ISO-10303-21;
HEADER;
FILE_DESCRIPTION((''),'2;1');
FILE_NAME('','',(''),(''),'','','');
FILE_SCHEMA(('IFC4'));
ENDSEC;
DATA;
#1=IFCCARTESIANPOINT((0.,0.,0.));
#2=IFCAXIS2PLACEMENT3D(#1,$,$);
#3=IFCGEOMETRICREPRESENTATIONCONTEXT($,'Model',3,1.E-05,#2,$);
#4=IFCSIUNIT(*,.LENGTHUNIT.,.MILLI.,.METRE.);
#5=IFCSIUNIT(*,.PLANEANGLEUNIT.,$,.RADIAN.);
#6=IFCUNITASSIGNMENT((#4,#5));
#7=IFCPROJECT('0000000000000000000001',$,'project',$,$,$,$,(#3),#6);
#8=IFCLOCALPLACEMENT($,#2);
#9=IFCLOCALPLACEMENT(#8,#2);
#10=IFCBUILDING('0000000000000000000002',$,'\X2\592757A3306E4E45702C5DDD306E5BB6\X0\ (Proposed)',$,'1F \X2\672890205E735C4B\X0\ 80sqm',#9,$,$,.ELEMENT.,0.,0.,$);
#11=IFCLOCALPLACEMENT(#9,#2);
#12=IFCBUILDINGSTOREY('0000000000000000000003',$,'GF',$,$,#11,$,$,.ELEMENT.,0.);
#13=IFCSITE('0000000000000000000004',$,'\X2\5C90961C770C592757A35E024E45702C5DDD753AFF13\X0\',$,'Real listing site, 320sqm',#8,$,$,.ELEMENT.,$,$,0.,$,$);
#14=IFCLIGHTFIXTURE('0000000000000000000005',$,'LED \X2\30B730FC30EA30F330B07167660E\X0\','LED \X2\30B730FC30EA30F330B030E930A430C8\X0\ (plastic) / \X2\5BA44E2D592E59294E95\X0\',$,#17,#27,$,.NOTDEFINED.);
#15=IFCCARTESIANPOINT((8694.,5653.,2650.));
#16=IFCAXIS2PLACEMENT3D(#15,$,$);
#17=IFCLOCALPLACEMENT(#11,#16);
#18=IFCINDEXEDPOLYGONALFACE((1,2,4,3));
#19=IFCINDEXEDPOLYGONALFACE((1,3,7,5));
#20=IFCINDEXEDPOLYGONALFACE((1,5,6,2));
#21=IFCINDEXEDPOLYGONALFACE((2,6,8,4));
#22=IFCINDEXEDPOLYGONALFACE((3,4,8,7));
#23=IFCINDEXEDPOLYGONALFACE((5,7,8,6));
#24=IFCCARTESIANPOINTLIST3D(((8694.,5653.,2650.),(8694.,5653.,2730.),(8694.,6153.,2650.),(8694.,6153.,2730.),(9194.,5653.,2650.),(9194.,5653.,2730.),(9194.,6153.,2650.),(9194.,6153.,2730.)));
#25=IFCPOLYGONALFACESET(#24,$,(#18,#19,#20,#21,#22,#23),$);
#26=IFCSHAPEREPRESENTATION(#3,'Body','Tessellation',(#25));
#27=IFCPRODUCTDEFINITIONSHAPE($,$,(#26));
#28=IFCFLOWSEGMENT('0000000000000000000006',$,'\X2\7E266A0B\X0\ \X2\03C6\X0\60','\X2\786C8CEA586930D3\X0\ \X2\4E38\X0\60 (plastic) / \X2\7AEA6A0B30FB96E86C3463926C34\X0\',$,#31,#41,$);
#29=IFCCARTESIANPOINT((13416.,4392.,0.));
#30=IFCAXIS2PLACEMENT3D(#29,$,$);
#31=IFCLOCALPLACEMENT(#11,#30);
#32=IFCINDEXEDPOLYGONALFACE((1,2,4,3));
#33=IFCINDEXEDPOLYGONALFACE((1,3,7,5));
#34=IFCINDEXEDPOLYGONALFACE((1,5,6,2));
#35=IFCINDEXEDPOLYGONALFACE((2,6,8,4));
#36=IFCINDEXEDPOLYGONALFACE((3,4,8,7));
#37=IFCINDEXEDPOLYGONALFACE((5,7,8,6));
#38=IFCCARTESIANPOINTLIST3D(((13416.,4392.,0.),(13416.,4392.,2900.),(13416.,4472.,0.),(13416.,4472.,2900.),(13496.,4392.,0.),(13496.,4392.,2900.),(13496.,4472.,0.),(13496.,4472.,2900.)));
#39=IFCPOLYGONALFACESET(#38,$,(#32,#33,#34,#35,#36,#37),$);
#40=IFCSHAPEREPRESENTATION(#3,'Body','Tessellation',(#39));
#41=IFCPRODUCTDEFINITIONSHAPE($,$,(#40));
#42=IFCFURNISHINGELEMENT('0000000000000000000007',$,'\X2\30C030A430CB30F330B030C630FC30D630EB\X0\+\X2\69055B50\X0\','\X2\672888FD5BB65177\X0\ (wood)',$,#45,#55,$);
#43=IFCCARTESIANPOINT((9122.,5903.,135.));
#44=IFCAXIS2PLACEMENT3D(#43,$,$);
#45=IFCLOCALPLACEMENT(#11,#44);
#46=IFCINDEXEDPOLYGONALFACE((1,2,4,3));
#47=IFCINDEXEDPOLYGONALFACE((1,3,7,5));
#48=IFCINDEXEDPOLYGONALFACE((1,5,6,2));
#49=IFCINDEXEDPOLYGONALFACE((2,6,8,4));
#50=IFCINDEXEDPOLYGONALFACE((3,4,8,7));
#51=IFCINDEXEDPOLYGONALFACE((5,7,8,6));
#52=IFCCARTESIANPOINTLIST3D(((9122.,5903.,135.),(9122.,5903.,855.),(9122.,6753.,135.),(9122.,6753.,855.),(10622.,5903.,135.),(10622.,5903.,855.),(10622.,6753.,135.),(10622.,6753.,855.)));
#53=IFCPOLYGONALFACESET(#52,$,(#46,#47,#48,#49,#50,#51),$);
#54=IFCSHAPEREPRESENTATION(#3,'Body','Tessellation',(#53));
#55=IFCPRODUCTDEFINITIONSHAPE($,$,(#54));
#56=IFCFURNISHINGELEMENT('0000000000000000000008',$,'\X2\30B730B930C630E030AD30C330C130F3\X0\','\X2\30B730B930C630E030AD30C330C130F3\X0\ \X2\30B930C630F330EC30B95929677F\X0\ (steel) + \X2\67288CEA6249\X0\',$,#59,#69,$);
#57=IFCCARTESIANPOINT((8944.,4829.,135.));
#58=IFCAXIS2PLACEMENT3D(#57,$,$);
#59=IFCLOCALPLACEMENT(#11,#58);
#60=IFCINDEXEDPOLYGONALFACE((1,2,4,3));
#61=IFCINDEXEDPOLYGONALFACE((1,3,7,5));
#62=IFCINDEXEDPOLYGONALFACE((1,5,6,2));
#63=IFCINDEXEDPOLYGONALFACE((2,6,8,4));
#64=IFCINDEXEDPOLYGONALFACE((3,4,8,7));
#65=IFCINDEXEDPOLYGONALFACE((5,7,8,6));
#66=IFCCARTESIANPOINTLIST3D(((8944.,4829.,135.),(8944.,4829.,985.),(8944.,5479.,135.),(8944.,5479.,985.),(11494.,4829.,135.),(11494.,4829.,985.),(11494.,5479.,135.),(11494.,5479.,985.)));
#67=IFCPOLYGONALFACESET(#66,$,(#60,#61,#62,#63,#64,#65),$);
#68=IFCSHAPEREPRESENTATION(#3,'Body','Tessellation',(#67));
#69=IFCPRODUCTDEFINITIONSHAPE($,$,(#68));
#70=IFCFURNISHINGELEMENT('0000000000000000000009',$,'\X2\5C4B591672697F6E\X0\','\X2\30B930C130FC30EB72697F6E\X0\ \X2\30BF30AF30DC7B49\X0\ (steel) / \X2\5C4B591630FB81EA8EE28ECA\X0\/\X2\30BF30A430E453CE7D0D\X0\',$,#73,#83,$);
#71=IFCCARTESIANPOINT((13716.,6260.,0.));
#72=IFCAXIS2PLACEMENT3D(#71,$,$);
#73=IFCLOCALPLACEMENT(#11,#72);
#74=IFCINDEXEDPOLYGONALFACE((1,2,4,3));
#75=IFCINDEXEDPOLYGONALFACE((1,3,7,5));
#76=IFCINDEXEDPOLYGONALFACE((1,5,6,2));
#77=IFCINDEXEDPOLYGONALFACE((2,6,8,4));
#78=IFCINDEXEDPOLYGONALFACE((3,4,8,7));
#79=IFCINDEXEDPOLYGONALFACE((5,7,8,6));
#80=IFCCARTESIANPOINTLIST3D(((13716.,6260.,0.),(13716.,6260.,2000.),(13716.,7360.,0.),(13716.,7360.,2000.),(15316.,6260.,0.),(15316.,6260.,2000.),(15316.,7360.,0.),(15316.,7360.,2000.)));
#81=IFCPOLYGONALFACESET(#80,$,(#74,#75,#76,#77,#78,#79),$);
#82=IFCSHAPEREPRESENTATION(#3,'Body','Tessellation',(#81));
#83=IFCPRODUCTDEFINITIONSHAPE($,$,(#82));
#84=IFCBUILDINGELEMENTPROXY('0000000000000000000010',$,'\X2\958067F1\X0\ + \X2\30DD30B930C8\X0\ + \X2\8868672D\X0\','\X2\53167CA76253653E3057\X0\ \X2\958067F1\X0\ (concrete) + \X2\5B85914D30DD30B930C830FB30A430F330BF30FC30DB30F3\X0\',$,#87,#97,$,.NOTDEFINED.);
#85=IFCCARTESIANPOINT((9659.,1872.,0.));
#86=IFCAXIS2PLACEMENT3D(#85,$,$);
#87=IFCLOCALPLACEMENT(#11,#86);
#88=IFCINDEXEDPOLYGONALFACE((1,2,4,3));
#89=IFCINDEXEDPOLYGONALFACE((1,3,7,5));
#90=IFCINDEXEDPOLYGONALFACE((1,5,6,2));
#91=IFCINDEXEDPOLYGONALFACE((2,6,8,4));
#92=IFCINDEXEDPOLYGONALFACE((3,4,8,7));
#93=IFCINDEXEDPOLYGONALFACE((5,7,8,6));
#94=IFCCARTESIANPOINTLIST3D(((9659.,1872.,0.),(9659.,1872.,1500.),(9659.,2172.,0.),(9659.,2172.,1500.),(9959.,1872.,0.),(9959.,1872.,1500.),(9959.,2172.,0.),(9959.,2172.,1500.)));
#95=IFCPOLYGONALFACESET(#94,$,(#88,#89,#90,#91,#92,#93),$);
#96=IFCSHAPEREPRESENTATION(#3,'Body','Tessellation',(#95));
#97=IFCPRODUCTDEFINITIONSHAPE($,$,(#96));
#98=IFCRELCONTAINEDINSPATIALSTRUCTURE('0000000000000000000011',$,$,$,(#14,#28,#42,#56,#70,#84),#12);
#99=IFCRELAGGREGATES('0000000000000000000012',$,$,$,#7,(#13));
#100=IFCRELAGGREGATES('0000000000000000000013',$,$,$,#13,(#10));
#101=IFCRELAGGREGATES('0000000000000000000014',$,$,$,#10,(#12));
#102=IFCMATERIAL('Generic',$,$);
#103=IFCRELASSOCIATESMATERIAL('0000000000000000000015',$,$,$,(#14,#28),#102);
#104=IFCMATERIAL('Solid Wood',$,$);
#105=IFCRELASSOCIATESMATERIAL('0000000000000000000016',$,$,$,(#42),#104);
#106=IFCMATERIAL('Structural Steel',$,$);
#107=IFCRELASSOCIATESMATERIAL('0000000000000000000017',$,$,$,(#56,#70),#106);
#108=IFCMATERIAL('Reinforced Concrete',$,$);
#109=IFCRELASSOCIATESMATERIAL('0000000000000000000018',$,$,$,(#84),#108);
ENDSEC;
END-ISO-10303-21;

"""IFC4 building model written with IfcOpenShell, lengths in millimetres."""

from ifc_helpers import new_model, si_unit, frame, frame_2d, origin, place, context, project, spatial, rectangle, extrude, material, element, save


model = new_model("IFC4")

# Units and contexts
model_context = context("Model", 3, precision=1e-05, world=origin())
ifc_project = project(units=[si_unit("LENGTHUNIT", "METRE", prefix="MILLI"), si_unit("PLANEANGLEUNIT", "RADIAN")], contexts=[model_context])

# Site, building, storey
site_placement = place(None, origin())
site = spatial("IfcSite", under=ifc_project, at=site_placement, Name="岐阜県大垣市久瀬川町３", ObjectType="Real listing site, 320sqm", CompositionType="ELEMENT", RefElevation=0.0)
building_placement = place(site_placement, origin())
building = spatial("IfcBuilding", under=site, at=building_placement, Name="大垣の久瀬川の家 (Proposed)", ObjectType="1F 木造平屋 80sqm", CompositionType="ELEMENT", ElevationOfRefHeight=0.0, ElevationOfTerrain=0.0)
storey_placement = place(building_placement, origin())
storey = spatial("IfcBuildingStorey", under=building, at=storey_placement, Name="GF", CompositionType="ELEMENT", Elevation=0.0)

# Shared definitions
ifc_material_1 = material(Name="Solid Wood")

# Shared definitions
ifc_material_2 = material(Name="Structural Steel")

# Shared definitions
ifc_material_3 = material(Name="Reinforced Concrete")

# Shared definitions
ifc_material_4 = material(Name="Generic")

# Light fixture
light_fixture_placement = place(storey_placement, frame((8694.0, 5653.0, 2650.0)))
element("IfcLightFixture", 1, at=light_fixture_placement, inside=storey, material=ifc_material_4, Name="LED シーリング照明", Description="LED シーリングライト (plastic) / 室中央天井", PredefinedType="NOTDEFINED", context=model_context, shape_type="SweptSolid", body=[
    extrude(rectangle(XDim=500.0, YDim=500.0, at=frame_2d((250.0, 250.0))), frame((8694.0, 5653.0, 2650.0)), (0.0, 0.0, 1.0), 80.0),
])

# Flow segment
flow_segment_placement = place(storey_placement, frame((13416.0, 4392.0, 0.0)))
element("IfcFlowSegment", 2, at=flow_segment_placement, inside=storey, material=ifc_material_4, Name="縦樋 φ60", Description="硬質塩ビ 丸60 (plastic) / 竪樋・雨水排水", context=model_context, shape_type="SweptSolid", body=[
    extrude(rectangle(XDim=80.0, YDim=80.0, at=frame_2d((40.0, 40.0))), frame((13416.0, 4392.0, 0.0)), (0.0, 0.0, 1.0), 2900.0),
])

# Furnishing elements
furnishing_1_placement = place(storey_placement, frame((9122.0, 5903.0, 135.0)))
element("IfcFurnishingElement", 3, at=furnishing_1_placement, inside=storey, material=ifc_material_1, Name="ダイニングテーブル+椅子", Description="木製家具 (wood)", context=model_context, shape_type="SweptSolid", body=[
    extrude(rectangle(XDim=1500.0, YDim=850.0, at=frame_2d((750.0, 425.0))), frame((9122.0, 5903.0, 135.0)), (0.0, 0.0, 1.0), 720.0),
])
furnishing_2_placement = place(storey_placement, frame((8944.0, 4829.0, 135.0)))
element("IfcFurnishingElement", 4, at=furnishing_2_placement, inside=storey, material=ifc_material_2, Name="システムキッチン", Description="システムキッチン ステンレス天板 (steel) + 木質扉", context=model_context, shape_type="SweptSolid", body=[
    extrude(rectangle(XDim=2550.0, YDim=650.0, at=frame_2d((1275.0, 325.0))), frame((8944.0, 4829.0, 135.0)), (0.0, 0.0, 1.0), 850.0),
])
furnishing_3_placement = place(storey_placement, frame((13716.0, 6260.0, 0.0)))
element("IfcFurnishingElement", 5, at=furnishing_3_placement, inside=storey, material=ifc_material_2, Name="屋外物置", Description="スチール物置 タクボ等 (steel) / 屋外・自転車/タイヤ収納", context=model_context, shape_type="SweptSolid", body=[
    extrude(rectangle(XDim=1600.0, YDim=1100.0, at=frame_2d((800.0, 550.0))), frame((13716.0, 6260.0, 0.0)), (0.0, 0.0, 1.0), 2000.0),
])

# Building element proxy
proxy_placement = place(storey_placement, frame((9659.0, 1872.0, 0.0)))
element("IfcBuildingElementProxy", 6, at=proxy_placement, inside=storey, material=ifc_material_3, Name="門柱 + ポスト + 表札", Description="化粧打放し 門柱 (concrete) + 宅配ポスト・インターホン", PredefinedType="NOTDEFINED", context=model_context, shape_type="SweptSolid", body=[
    extrude(rectangle(XDim=300.0, YDim=300.0, at=frame_2d((150.0, 150.0))), frame((9659.0, 1872.0, 0.0)), (0.0, 0.0, 1.0), 1500.0),
])

save(model, "model.ifc")
